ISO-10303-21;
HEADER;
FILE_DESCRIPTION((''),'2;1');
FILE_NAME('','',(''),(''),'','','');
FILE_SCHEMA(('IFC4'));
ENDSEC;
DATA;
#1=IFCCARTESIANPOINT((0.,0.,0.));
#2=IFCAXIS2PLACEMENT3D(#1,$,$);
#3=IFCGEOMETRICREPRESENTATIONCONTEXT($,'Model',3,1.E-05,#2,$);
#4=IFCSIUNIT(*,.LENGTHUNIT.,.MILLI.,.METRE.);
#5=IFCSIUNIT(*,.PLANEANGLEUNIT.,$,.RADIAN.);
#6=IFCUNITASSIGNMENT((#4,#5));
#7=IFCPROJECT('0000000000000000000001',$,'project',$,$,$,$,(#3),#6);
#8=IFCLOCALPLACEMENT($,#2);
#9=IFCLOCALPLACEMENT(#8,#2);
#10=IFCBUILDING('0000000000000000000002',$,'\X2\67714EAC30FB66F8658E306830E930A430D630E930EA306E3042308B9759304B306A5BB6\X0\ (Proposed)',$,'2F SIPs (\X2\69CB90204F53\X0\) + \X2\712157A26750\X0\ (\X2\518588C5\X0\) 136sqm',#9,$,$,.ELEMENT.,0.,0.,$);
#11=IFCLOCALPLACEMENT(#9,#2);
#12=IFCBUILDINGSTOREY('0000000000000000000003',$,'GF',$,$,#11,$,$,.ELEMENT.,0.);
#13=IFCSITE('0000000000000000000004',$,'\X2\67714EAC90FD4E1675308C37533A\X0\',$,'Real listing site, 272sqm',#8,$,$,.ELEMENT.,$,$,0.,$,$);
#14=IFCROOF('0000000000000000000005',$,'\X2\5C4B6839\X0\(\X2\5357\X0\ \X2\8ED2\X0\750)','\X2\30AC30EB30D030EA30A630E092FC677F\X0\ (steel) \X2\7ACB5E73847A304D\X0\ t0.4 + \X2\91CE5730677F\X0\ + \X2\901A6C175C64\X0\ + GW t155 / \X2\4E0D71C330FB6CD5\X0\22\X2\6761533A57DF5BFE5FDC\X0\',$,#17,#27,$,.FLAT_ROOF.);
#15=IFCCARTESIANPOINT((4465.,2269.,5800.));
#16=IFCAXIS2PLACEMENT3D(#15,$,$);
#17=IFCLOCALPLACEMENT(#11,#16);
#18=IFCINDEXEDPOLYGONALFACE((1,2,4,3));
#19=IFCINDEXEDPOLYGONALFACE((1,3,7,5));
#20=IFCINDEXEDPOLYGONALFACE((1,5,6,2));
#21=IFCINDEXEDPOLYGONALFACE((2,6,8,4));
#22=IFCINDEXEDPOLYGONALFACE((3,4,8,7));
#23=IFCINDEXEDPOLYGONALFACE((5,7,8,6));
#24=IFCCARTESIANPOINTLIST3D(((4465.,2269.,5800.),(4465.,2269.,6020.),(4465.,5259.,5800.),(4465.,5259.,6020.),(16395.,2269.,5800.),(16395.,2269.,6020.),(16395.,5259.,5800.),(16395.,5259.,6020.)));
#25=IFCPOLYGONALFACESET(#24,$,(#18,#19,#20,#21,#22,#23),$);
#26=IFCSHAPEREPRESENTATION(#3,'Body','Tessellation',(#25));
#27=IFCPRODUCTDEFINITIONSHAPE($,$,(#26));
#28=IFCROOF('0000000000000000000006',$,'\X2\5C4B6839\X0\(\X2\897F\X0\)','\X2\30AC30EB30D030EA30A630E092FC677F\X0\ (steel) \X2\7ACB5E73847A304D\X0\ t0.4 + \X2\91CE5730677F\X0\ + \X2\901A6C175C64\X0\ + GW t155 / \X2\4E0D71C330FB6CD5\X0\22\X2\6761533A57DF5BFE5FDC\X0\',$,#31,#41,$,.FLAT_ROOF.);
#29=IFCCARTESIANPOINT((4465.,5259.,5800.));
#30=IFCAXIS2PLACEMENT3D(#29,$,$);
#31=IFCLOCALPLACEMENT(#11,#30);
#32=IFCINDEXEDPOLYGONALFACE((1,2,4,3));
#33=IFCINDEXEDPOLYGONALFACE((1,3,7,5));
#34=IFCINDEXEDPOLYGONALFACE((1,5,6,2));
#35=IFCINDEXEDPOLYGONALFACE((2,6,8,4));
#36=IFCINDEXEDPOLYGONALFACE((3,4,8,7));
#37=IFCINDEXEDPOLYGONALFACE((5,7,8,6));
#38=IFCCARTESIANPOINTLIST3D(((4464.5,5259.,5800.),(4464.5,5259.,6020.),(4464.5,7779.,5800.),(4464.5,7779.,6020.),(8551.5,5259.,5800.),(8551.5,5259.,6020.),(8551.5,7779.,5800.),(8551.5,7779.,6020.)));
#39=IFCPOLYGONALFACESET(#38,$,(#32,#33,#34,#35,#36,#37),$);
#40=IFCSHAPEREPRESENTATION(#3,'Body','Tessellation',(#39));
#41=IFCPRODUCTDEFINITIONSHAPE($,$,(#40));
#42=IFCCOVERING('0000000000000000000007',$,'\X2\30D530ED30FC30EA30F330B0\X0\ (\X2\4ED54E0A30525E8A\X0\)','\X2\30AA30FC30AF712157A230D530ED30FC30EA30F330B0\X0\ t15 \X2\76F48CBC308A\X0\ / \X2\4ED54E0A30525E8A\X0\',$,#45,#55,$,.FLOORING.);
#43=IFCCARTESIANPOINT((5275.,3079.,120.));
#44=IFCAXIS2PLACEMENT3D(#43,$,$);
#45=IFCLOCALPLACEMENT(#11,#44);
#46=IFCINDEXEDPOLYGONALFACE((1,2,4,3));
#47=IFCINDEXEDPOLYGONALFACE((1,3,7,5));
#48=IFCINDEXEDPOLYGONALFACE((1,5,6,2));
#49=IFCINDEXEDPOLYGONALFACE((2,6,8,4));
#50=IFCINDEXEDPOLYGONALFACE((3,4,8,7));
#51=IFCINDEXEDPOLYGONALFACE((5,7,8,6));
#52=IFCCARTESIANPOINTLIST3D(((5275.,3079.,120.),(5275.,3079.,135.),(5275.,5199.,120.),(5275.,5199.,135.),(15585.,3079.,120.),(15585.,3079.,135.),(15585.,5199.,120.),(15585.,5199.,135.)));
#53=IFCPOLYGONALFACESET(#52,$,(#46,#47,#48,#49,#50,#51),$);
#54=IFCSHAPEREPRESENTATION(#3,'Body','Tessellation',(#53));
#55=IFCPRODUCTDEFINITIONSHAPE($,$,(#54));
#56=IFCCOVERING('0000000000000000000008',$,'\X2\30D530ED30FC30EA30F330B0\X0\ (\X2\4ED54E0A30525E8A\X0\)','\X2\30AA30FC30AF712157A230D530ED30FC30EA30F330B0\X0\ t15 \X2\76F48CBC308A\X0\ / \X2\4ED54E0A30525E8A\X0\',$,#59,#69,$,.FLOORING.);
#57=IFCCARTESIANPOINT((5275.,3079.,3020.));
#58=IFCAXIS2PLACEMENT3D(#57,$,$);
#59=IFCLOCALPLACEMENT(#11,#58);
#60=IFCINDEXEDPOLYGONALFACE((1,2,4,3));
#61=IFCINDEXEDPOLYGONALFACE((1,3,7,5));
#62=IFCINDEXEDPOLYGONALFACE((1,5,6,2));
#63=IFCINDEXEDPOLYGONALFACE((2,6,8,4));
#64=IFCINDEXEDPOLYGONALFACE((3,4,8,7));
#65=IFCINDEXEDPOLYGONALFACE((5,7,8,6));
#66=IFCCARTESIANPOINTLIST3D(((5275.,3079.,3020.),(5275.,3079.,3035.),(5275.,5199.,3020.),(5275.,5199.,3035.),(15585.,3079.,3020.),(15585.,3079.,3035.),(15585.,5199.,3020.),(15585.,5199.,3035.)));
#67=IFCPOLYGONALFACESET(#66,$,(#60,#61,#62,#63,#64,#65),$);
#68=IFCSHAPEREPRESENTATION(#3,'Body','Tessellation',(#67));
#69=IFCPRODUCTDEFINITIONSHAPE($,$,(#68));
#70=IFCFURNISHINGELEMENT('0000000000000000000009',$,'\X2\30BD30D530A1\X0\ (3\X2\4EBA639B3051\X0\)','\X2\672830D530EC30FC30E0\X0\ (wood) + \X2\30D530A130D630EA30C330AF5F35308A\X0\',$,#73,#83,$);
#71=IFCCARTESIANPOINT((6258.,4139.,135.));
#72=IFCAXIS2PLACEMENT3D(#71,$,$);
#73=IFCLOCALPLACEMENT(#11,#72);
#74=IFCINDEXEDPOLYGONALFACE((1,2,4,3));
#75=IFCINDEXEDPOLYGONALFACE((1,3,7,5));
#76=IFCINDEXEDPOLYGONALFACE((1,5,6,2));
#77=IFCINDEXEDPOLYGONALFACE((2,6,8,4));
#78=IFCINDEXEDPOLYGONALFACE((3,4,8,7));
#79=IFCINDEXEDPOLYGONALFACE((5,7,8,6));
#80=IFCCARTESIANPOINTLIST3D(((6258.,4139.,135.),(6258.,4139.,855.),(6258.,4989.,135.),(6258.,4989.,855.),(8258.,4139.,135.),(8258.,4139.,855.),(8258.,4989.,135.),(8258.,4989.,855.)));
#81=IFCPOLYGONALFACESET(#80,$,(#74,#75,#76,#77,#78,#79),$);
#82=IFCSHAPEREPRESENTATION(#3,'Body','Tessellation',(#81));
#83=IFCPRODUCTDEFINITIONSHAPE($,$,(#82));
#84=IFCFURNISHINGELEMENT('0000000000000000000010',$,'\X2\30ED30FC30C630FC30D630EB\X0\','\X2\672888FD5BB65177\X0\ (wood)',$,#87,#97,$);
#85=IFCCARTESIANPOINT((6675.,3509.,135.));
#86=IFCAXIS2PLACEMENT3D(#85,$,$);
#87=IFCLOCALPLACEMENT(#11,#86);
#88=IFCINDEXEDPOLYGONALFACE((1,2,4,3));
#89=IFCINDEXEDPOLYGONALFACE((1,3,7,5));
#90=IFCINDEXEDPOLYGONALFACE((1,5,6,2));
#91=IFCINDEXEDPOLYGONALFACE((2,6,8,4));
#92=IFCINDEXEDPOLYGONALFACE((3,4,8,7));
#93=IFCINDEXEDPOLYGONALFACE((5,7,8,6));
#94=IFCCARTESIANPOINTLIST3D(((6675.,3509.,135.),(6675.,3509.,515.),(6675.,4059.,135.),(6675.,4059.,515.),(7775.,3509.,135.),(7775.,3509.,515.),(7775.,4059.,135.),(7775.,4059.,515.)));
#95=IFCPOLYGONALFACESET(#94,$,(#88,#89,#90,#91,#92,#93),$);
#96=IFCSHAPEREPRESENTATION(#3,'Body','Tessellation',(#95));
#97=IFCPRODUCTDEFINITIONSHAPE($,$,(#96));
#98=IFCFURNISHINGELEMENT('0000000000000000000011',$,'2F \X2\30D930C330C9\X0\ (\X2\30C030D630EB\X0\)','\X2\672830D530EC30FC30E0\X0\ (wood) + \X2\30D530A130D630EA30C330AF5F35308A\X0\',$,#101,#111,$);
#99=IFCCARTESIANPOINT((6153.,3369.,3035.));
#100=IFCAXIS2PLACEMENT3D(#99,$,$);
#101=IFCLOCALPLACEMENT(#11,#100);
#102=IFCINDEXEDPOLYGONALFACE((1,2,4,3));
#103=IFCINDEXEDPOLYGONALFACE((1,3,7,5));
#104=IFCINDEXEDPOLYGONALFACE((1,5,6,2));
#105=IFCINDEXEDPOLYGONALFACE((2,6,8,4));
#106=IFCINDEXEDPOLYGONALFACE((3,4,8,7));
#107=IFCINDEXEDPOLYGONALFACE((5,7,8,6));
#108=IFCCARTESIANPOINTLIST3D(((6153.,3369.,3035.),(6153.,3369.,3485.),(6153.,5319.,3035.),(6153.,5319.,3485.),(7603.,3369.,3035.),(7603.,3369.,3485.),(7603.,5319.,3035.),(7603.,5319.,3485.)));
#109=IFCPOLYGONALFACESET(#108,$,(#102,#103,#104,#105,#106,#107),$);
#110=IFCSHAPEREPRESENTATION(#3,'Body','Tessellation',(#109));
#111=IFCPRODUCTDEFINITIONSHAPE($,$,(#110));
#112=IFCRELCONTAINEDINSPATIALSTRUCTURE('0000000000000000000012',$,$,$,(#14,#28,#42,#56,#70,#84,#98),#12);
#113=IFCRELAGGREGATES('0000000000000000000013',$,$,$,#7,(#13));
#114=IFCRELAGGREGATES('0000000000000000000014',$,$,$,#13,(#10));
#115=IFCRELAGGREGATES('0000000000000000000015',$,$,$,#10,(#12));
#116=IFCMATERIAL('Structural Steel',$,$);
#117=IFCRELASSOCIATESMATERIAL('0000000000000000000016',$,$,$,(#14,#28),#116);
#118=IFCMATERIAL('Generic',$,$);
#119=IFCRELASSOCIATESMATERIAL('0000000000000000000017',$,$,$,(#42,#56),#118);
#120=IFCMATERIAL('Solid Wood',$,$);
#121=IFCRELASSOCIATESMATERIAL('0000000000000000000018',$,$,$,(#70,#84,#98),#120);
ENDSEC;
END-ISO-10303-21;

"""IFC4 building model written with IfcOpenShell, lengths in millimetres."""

from ifc_helpers import new_model, si_unit, frame, frame_2d, origin, place, context, project, spatial, rectangle, extrude, material, element, save


model = new_model("IFC4")

# Units and contexts
model_context = context("Model", 3, precision=1e-05, world=origin())
ifc_project = project(units=[si_unit("LENGTHUNIT", "METRE", prefix="MILLI"), si_unit("PLANEANGLEUNIT", "RADIAN")], contexts=[model_context])

# Site, building, storey
site_placement = place(None, origin())
site = spatial("IfcSite", under=ifc_project, at=site_placement, Name="東京都世田谷区", ObjectType="Real listing site, 272sqm", CompositionType="ELEMENT", RefElevation=0.0)
building_placement = place(site_placement, origin())
building = spatial("IfcBuilding", under=site, at=building_placement, Name="東京・書斎とライブラリのある静かな家 (Proposed)", ObjectType="2F SIPs (構造体) + 無垢材 (内装) 136sqm", CompositionType="ELEMENT", ElevationOfRefHeight=0.0, ElevationOfTerrain=0.0)
storey_placement = place(building_placement, origin())
storey = spatial("IfcBuildingStorey", under=building, at=storey_placement, Name="GF", CompositionType="ELEMENT", Elevation=0.0)

# Shared definitions
ifc_material_1 = material(Name="Solid Wood")

# Roofs
ifc_material_2 = material(Name="Structural Steel")
roof_1_placement = place(storey_placement, frame((4465.0, 2269.0, 5800.0)))
element("IfcRoof", 1, at=roof_1_placement, inside=storey, material=ifc_material_2, Name="屋根(南 軒750)", Description="ガルバリウム鋼板 (steel) 立平葺き t0.4 + 野地板 + 通気層 + GW t155 / 不燃・法22条区域対応", PredefinedType="FLAT_ROOF", context=model_context, shape_type="SweptSolid", body=[
    extrude(rectangle(XDim=11930.0, YDim=2990.0, at=frame_2d((5965.0, 1495.0))), frame((4465.0, 2269.0, 5800.0)), (0.0, 0.0, 1.0), 220.0),
])
roof_2_placement = place(storey_placement, frame((4465.0, 5259.0, 5800.0)))
element("IfcRoof", 2, at=roof_2_placement, inside=storey, material=ifc_material_2, Name="屋根(西)", Description="ガルバリウム鋼板 (steel) 立平葺き t0.4 + 野地板 + 通気層 + GW t155 / 不燃・法22条区域対応", PredefinedType="FLAT_ROOF", context=model_context, shape_type="SweptSolid", body=[
    extrude(rectangle(XDim=4087.0, YDim=2520.0, at=frame_2d((2043.0, 1260.0))), frame((4465.0, 5259.0, 5800.0)), (0.0, 0.0, 1.0), 220.0),
])

# Coverings
ifc_material_3 = material(Name="Generic")
covering_1_placement = place(storey_placement, frame((5275.0, 3079.0, 120.0)))
element("IfcCovering", 3, at=covering_1_placement, inside=storey, material=ifc_material_3, Name="フローリング (仕上げ床)", Description="オーク無垢フローリング t15 直貼り / 仕上げ床", PredefinedType="FLOORING", context=model_context, shape_type="SweptSolid", body=[
    extrude(rectangle(XDim=10310.0, YDim=2120.0, at=frame_2d((5155.0, 1060.0))), frame((5275.0, 3079.0, 120.0)), (0.0, 0.0, 1.0), 15.0),
])
covering_2_placement = place(storey_placement, frame((5275.0, 3079.0, 3020.0)))
element("IfcCovering", 4, at=covering_2_placement, inside=storey, material=ifc_material_3, Name="フローリング (仕上げ床)", Description="オーク無垢フローリング t15 直貼り / 仕上げ床", PredefinedType="FLOORING", context=model_context, shape_type="SweptSolid", body=[
    extrude(rectangle(XDim=10310.0, YDim=2120.0, at=frame_2d((5155.0, 1060.0))), frame((5275.0, 3079.0, 3020.0)), (0.0, 0.0, 1.0), 15.0),
])

# Furnishing elements
furnishing_1_placement = place(storey_placement, frame((6258.0, 4139.0, 135.0)))
element("IfcFurnishingElement", 5, at=furnishing_1_placement, inside=storey, material=ifc_material_1, Name="ソファ (3人掛け)", Description="木フレーム (wood) + ファブリック張り", context=model_context, shape_type="SweptSolid", body=[
    extrude(rectangle(XDim=2000.0, YDim=850.0, at=frame_2d((1000.0, 425.0))), frame((6258.0, 4139.0, 135.0)), (0.0, 0.0, 1.0), 720.0),
])
furnishing_2_placement = place(storey_placement, frame((6675.0, 3509.0, 135.0)))
element("IfcFurnishingElement", 6, at=furnishing_2_placement, inside=storey, material=ifc_material_1, Name="ローテーブル", Description="木製家具 (wood)", context=model_context, shape_type="SweptSolid", body=[
    extrude(rectangle(XDim=1100.0, YDim=550.0, at=frame_2d((550.0, 275.0))), frame((6675.0, 3509.0, 135.0)), (0.0, 0.0, 1.0), 380.0),
])
furnishing_3_placement = place(storey_placement, frame((6153.0, 3369.0, 3035.0)))
element("IfcFurnishingElement", 7, at=furnishing_3_placement, inside=storey, material=ifc_material_1, Name="2F ベッド (ダブル)", Description="木フレーム (wood) + ファブリック張り", context=model_context, shape_type="SweptSolid", body=[
    extrude(rectangle(XDim=1450.0, YDim=1950.0, at=frame_2d((725.0, 975.0))), frame((6153.0, 3369.0, 3035.0)), (0.0, 0.0, 1.0), 450.0),
])

save(model, "model.ifc")
